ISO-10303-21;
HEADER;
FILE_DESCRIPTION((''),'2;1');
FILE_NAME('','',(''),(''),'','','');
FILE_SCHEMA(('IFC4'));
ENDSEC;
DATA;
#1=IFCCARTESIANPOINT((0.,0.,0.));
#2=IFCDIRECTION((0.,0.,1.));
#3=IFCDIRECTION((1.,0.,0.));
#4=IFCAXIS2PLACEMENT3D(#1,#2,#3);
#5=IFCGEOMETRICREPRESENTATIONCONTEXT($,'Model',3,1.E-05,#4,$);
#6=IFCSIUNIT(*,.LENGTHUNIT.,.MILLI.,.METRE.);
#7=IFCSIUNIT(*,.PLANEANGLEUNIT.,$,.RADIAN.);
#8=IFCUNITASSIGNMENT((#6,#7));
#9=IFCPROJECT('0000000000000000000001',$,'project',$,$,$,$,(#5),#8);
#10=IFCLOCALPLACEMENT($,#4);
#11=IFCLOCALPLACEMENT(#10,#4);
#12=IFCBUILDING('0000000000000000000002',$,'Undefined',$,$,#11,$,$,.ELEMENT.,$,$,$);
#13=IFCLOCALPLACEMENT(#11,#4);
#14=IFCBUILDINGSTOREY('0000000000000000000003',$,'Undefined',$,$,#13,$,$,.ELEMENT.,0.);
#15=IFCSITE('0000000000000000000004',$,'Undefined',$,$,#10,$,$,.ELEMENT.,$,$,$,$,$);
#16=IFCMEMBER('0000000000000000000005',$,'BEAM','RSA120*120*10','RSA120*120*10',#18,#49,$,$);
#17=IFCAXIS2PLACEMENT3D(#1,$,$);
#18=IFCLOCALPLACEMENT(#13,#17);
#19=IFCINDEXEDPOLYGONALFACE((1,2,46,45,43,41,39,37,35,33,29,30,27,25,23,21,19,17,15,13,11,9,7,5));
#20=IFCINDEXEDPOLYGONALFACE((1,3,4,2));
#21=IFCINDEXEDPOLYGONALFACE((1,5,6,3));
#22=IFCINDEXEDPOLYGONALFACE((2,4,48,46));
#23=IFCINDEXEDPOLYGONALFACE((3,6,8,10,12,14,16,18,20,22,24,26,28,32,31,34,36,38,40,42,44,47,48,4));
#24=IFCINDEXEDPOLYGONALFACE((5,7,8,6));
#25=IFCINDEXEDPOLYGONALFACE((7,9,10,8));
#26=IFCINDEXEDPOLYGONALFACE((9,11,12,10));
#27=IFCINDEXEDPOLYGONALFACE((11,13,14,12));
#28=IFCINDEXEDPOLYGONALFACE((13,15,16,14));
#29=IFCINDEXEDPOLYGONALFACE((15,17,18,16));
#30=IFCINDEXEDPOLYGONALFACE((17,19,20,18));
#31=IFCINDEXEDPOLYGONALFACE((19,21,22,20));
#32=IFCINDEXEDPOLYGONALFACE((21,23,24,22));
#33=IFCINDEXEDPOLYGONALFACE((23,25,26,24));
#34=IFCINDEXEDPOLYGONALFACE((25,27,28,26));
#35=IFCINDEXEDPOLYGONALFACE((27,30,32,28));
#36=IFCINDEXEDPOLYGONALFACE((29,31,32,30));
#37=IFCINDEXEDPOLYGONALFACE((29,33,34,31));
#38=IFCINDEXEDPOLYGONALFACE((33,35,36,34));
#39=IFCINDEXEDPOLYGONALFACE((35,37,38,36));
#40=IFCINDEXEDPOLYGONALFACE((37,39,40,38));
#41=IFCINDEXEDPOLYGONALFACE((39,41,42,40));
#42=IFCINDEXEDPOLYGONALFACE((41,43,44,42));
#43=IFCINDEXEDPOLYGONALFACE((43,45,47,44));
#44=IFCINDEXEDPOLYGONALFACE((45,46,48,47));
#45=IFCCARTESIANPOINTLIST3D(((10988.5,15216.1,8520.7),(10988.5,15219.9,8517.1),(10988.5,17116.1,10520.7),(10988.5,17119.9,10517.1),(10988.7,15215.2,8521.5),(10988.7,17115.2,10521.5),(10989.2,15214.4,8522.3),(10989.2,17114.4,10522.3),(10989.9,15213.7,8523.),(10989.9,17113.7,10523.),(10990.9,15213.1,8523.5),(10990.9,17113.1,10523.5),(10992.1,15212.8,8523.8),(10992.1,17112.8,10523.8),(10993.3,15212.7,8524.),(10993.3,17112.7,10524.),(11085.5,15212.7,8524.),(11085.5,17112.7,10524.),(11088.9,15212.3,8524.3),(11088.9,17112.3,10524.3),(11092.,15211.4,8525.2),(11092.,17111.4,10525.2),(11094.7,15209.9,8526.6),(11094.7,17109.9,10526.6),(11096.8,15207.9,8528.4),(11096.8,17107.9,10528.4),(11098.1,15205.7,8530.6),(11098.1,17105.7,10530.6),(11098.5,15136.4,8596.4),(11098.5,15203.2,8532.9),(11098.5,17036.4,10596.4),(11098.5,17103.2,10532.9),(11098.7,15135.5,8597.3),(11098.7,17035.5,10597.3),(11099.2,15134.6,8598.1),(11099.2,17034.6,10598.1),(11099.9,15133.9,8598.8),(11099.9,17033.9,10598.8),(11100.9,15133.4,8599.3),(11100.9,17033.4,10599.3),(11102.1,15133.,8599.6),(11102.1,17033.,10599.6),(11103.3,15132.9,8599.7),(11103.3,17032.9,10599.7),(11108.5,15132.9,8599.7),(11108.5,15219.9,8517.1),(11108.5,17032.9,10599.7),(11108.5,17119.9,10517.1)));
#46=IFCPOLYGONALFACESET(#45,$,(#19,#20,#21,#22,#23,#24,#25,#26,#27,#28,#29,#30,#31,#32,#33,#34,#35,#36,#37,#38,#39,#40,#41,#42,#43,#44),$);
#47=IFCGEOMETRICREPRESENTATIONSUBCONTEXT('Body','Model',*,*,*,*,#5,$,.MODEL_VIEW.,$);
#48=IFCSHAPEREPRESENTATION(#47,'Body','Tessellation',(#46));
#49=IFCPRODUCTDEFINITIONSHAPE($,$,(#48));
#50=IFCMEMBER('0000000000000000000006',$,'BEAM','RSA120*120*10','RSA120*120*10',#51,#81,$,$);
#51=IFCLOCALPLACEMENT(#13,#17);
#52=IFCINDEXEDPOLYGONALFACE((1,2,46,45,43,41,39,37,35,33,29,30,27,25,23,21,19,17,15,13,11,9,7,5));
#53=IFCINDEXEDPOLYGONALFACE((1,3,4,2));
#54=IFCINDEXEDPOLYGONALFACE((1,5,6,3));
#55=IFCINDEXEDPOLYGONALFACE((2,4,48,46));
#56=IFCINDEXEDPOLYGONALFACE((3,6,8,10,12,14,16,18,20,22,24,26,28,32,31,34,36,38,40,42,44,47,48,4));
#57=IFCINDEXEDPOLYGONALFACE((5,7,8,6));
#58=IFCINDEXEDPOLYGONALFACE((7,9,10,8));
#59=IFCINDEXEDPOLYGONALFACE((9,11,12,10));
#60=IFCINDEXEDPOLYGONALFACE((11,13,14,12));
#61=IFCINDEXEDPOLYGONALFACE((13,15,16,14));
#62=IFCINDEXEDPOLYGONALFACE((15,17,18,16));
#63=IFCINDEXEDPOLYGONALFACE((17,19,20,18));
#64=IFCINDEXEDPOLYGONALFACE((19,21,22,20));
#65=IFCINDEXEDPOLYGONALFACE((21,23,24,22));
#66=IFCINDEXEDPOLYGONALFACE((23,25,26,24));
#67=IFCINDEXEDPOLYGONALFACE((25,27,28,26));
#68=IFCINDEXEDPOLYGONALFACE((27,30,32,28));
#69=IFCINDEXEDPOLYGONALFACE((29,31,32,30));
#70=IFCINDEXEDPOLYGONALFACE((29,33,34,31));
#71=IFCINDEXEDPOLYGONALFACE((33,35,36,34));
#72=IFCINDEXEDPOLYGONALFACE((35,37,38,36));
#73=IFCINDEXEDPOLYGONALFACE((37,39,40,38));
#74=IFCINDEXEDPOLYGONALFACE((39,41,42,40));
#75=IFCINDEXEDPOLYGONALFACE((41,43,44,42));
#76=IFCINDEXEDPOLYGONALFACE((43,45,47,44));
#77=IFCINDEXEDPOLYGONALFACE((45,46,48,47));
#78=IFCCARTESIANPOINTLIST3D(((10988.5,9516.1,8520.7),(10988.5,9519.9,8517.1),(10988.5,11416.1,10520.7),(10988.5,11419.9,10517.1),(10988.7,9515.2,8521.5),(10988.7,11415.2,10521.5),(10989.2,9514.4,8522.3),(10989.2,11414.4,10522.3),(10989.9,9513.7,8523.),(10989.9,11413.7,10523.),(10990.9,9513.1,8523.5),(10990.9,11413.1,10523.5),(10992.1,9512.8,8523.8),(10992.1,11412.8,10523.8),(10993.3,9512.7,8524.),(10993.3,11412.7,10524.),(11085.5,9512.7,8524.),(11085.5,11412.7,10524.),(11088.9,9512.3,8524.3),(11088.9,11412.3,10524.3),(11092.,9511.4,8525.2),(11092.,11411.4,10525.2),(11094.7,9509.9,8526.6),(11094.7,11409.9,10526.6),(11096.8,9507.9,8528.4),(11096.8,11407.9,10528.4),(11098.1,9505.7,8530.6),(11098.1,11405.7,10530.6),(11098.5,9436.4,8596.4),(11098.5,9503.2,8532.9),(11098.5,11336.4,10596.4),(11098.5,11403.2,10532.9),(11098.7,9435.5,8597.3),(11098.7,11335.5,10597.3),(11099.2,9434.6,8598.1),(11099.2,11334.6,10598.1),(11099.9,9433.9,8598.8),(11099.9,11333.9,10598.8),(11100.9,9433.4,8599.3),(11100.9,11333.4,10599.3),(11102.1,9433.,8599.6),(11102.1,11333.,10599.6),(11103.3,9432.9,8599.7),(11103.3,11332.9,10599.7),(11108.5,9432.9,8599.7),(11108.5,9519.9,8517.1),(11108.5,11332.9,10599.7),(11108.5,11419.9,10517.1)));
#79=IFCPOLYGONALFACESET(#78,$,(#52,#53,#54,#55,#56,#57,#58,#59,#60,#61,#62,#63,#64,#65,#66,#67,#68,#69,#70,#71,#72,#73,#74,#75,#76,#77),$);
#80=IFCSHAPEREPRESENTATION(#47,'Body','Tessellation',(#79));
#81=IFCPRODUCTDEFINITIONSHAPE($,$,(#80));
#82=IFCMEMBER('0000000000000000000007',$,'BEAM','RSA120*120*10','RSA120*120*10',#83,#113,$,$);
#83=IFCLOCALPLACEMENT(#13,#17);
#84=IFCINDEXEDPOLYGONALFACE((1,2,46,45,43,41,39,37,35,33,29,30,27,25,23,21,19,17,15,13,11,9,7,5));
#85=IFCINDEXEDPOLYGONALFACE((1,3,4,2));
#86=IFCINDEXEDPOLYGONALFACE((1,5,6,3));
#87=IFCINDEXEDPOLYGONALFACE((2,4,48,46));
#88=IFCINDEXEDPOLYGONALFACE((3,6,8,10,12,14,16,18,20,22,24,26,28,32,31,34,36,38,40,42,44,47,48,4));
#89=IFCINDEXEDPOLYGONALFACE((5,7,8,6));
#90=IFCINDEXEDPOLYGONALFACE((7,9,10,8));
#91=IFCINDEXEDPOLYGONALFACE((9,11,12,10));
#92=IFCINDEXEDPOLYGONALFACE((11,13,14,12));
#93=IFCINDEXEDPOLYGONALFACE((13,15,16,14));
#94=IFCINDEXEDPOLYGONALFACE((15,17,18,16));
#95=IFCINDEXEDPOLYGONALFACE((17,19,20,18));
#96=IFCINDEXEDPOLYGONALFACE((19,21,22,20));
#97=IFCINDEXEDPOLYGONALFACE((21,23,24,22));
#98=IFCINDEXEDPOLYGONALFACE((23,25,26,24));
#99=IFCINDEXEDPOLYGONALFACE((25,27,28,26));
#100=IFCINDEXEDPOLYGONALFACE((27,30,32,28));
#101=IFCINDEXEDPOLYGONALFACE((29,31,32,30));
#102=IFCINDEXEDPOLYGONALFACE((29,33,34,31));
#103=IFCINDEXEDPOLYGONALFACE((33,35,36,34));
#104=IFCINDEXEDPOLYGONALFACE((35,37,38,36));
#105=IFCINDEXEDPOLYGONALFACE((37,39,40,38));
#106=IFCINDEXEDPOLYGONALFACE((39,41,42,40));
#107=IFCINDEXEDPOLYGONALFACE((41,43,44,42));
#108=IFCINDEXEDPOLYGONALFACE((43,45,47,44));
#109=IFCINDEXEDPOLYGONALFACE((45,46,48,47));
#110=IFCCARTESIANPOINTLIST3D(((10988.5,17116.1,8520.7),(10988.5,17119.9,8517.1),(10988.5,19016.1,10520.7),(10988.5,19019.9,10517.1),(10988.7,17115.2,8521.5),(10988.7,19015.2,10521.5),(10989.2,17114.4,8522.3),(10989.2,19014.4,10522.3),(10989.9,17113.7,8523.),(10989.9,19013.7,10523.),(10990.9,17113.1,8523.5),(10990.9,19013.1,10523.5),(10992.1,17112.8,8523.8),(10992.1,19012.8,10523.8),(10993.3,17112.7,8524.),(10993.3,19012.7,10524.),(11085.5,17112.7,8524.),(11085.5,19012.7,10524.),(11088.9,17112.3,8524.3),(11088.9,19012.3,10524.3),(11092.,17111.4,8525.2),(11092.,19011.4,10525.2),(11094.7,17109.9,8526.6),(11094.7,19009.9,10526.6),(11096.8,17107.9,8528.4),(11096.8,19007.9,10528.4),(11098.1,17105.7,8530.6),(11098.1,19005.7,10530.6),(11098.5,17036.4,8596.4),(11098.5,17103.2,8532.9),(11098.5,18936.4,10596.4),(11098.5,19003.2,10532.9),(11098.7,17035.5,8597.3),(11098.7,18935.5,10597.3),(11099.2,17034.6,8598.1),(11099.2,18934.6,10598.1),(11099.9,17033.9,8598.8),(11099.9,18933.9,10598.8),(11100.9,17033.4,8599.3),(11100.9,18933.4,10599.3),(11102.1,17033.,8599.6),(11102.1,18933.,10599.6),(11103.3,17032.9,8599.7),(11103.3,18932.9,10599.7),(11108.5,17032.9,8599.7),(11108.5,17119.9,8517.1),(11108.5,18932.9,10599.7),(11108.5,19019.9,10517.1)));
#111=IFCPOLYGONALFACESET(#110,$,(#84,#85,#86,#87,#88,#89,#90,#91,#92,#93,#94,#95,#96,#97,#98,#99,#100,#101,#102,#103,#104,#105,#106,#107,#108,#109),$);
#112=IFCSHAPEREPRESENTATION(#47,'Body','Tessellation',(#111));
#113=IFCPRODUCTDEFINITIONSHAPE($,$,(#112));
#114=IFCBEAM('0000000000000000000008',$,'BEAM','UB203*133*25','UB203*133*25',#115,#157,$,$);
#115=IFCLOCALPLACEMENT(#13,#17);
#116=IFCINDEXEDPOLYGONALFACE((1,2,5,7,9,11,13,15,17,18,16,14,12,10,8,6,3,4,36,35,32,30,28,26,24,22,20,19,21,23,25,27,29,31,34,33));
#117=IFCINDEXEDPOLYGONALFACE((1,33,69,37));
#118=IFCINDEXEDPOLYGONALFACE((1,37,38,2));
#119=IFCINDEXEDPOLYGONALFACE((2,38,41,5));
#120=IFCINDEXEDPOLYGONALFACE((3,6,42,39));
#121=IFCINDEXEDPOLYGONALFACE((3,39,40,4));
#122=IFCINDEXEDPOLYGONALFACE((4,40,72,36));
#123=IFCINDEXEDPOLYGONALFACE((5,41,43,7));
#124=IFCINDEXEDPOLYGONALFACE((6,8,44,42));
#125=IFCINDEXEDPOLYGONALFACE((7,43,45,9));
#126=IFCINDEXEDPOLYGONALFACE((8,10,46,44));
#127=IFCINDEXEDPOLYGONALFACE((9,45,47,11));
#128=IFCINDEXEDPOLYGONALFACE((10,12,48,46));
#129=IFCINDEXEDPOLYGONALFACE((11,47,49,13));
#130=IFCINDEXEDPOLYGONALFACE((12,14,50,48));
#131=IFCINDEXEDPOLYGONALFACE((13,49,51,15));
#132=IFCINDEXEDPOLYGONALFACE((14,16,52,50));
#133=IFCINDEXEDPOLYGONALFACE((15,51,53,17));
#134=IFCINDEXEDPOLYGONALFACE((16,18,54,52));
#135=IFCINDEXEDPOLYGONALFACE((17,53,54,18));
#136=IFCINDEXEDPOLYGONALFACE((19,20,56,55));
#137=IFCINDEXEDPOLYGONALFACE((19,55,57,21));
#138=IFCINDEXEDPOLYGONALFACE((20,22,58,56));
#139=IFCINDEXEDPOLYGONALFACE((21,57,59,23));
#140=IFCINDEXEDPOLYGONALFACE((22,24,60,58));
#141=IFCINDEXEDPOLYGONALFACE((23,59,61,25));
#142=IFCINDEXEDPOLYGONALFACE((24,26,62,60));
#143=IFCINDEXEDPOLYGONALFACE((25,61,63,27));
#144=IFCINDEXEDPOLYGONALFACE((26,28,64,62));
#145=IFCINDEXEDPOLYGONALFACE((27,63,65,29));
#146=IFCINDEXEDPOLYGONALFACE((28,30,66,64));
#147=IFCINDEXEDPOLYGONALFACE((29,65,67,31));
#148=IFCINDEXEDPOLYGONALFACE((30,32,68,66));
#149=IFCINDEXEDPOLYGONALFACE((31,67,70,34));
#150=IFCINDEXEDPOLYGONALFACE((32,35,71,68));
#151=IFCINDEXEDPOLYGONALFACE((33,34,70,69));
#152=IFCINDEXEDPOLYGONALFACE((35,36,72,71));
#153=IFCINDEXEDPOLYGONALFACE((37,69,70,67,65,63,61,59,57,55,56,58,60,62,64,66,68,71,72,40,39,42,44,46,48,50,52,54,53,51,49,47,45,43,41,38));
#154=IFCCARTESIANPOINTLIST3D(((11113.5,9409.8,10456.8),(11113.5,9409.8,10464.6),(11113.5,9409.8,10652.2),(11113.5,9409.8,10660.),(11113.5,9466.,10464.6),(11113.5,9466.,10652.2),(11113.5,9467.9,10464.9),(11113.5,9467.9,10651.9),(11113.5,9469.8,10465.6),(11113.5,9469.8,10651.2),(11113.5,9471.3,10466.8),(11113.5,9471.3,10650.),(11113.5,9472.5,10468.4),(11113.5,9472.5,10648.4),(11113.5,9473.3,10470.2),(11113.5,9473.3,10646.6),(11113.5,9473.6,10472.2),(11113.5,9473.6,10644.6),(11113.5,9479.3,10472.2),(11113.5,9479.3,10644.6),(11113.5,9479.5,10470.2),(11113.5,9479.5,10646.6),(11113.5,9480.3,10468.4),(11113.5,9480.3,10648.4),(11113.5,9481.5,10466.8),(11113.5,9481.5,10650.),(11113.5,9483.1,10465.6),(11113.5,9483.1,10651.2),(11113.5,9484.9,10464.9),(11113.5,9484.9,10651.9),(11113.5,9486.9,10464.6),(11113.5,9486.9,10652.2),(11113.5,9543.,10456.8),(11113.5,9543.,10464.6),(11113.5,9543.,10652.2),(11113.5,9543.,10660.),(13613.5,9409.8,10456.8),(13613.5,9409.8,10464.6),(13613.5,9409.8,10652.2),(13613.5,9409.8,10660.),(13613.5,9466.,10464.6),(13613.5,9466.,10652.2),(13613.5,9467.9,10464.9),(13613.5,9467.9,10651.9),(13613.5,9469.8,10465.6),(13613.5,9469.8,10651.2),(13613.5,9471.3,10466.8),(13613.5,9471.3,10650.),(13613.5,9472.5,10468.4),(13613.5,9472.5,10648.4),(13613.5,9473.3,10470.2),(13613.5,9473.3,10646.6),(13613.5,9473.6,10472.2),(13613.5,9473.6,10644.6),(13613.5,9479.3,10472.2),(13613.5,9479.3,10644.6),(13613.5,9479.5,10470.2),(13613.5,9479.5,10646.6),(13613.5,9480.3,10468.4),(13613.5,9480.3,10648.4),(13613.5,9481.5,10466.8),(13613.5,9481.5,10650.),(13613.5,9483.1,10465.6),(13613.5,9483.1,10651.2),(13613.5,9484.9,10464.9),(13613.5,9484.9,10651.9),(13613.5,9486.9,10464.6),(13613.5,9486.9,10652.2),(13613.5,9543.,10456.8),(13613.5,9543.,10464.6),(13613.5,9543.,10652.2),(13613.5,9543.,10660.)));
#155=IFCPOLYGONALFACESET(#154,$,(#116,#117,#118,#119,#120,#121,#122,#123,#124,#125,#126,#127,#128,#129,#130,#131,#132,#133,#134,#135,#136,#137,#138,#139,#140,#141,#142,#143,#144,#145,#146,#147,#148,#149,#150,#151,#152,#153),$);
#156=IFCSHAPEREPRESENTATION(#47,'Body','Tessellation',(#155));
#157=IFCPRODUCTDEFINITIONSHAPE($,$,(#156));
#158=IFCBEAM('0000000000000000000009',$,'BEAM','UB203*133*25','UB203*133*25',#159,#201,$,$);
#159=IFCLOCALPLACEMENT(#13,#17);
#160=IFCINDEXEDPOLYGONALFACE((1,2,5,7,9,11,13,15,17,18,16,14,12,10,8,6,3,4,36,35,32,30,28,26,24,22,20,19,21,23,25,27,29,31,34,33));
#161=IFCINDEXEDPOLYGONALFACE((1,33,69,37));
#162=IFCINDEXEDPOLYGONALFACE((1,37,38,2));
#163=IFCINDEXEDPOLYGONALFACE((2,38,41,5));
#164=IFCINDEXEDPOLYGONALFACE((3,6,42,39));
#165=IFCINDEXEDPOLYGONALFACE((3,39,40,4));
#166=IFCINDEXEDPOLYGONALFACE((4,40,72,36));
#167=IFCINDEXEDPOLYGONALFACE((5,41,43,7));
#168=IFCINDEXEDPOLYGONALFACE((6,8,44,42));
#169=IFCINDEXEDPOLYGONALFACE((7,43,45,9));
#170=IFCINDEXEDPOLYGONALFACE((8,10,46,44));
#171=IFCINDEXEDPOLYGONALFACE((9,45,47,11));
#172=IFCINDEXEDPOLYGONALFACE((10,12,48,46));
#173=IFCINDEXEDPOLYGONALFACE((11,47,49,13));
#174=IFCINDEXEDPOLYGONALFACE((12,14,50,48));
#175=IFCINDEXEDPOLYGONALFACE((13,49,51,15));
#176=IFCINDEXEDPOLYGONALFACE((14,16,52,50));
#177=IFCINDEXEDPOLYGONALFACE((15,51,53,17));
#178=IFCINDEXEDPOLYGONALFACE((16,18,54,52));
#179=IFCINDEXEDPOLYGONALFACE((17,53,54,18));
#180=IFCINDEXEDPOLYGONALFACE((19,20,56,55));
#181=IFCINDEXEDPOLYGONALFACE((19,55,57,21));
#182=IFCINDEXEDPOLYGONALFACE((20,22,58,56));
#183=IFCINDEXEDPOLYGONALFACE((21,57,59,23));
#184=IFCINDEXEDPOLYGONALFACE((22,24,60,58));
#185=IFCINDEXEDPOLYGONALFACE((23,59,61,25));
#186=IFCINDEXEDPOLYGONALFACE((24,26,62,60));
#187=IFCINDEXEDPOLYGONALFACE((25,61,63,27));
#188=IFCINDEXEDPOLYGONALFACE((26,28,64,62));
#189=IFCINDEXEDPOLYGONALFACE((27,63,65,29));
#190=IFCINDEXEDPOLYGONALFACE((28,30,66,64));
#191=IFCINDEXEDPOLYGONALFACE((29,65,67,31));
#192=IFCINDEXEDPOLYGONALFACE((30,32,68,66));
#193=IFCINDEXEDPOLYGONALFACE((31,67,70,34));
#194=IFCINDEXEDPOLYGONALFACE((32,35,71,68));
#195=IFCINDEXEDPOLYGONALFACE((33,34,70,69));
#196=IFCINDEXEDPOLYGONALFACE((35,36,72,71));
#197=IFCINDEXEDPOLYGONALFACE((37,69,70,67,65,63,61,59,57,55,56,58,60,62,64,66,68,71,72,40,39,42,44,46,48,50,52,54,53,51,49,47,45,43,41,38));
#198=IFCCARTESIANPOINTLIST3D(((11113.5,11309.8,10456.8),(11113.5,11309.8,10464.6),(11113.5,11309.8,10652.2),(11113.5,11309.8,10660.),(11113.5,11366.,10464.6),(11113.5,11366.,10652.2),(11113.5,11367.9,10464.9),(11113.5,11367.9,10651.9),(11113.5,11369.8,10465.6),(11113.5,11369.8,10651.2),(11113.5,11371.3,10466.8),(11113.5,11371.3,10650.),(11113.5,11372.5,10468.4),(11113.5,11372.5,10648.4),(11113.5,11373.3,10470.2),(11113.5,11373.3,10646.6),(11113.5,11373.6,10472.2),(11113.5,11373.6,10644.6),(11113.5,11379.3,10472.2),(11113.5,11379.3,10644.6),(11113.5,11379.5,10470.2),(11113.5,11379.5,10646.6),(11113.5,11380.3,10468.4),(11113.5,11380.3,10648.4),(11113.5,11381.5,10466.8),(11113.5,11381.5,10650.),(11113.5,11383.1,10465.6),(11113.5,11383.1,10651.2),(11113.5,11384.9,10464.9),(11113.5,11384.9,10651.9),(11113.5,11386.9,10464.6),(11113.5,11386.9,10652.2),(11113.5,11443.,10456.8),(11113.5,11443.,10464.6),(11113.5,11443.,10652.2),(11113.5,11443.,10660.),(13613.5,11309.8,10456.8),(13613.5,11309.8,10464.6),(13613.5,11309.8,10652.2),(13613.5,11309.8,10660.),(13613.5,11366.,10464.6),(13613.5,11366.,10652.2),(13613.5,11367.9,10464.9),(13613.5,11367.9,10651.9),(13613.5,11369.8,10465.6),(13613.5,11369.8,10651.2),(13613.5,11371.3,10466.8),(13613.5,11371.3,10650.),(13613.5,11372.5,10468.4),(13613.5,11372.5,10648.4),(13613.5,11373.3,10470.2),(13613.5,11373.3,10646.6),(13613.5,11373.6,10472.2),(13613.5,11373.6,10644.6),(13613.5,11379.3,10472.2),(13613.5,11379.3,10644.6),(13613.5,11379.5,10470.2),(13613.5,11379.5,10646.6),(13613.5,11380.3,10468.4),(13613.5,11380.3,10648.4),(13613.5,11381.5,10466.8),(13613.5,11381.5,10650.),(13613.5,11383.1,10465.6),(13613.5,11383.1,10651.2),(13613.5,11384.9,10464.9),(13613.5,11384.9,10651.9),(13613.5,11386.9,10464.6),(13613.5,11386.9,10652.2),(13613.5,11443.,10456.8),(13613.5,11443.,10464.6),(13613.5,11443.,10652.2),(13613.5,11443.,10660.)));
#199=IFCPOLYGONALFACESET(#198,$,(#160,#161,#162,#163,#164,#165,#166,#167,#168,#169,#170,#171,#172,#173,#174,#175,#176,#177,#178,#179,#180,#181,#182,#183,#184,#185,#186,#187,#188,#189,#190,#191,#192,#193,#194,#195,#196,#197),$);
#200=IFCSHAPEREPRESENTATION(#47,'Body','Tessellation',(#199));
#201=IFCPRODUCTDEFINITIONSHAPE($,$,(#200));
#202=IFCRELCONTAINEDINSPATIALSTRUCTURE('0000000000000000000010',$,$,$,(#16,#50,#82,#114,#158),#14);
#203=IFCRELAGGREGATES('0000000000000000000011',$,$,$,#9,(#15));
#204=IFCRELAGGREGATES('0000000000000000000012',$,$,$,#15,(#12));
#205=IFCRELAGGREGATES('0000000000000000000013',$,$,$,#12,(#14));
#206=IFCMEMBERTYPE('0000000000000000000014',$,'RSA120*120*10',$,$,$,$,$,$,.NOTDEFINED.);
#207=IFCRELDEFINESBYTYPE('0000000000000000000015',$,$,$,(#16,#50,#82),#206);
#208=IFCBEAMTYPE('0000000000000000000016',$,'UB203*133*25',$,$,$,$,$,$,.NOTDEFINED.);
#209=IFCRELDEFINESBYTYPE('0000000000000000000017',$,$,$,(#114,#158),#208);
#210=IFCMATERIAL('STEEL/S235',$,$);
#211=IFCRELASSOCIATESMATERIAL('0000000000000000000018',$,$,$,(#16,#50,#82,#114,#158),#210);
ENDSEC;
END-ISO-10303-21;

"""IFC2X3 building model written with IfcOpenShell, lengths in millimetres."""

from ifc_helpers import new_model, si_unit, frame, origin_with_axes, origin_2d_with_axis, place, context, subcontext, project, spatial, i_section, l_section, extrude, material, type_object, element, save


model = new_model("IFC2X3")

# Units and contexts
model_context = context("Model", 3, precision=1e-05, world=origin_with_axes())
body_context = subcontext(model_context, "Body", "Model", "MODEL_VIEW")
ifc_project = project(units=[si_unit("LENGTHUNIT", "METRE", prefix="MILLI"), si_unit("PLANEANGLEUNIT", "RADIAN")], contexts=[model_context])

# Site, building, storey
site_placement = place(None, origin_with_axes())
site = spatial("IfcSite", under=ifc_project, at=site_placement, Name="Undefined", CompositionType="ELEMENT")
building_placement = place(site_placement, origin_with_axes())
building = spatial("IfcBuilding", under=site, at=building_placement, Name="Undefined", CompositionType="ELEMENT")
storey_placement = place(building_placement, origin_with_axes())
storey = spatial("IfcBuildingStorey", under=building, at=storey_placement, Name="Undefined", CompositionType="ELEMENT", Elevation=0.0)

# Shared definitions
ifc_material = material(Name="STEEL/S235")

# Members
member_type = type_object("IfcMemberType", Name="RSA120*120*10", PredefinedType="NOTDEFINED")
for number, where, z_axis, x_axis, name in (
    (1, (11048.5, 17076.4, 10558.4), (0.0, -0.724999, 0.688749), (0.0, -0.688749, -0.724999), "BEAM"),
    (2, (11048.5, 11376.4, 10558.4), (0.0, -0.724999, 0.688749), (0.0, -0.688749, -0.724999), "BEAM"),
    (3, (11048.5, 18976.4, 10558.4), (0.0, -0.724999, 0.688749), (0.0, -0.688749, -0.724999), "BEAM"),
):
    element("IfcMember", number, at=place(storey_placement, frame(where, z_axis=z_axis, x_axis=x_axis)), inside=storey, type_object=member_type, material=ifc_material, Name=name, Description="RSA120*120*10", ObjectType="RSA120*120*10", context=body_context, shape_type="SweptSolid", body=[
        extrude(l_section(Depth=120.0, Width=120.0, Thickness=10.0, FilletRadius=13.0, EdgeRadius=4.8, at=origin_2d_with_axis()), frame((2758.6, 0.0, 0.0), z_axis=(-1.0, 0.0, 0.0), x_axis=(0.0, -1.0, 0.0)), (0.0, 0.0, 1.0), 2758.6),
    ])

# Beams
beam_type_1 = type_object("IfcBeamType", Name="UB203*133*25", PredefinedType="NOTDEFINED")
for number, where, z_axis, x_axis, name in (
    (4, (11113.5, 9476.4, 10558.4), (0.0, 0.0, 1.0), (1.0, 0.0, 0.0), "BEAM"),
    (5, (11113.5, 11376.4, 10558.4), (0.0, 0.0, 1.0), (1.0, 0.0, 0.0), "BEAM"),
):
    element("IfcBeam", number, at=place(storey_placement, frame(where, z_axis=z_axis, x_axis=x_axis)), inside=storey, type_object=beam_type_1, material=ifc_material, Name=name, Description="UB203*133*25", ObjectType="UB203*133*25", context=body_context, shape_type="SweptSolid", body=[
        extrude(i_section(OverallWidth=133.2, OverallDepth=203.2, WebThickness=5.7, FlangeThickness=7.8, FilletRadius=7.6, at=origin_2d_with_axis()), frame((2500.0, 0.0, 0.0), z_axis=(-1.0, 0.0, 0.0), x_axis=(0.0, -1.0, 0.0)), (0.0, 0.0, 1.0), 2500.0),
    ])

save(model, "model.ifc")
